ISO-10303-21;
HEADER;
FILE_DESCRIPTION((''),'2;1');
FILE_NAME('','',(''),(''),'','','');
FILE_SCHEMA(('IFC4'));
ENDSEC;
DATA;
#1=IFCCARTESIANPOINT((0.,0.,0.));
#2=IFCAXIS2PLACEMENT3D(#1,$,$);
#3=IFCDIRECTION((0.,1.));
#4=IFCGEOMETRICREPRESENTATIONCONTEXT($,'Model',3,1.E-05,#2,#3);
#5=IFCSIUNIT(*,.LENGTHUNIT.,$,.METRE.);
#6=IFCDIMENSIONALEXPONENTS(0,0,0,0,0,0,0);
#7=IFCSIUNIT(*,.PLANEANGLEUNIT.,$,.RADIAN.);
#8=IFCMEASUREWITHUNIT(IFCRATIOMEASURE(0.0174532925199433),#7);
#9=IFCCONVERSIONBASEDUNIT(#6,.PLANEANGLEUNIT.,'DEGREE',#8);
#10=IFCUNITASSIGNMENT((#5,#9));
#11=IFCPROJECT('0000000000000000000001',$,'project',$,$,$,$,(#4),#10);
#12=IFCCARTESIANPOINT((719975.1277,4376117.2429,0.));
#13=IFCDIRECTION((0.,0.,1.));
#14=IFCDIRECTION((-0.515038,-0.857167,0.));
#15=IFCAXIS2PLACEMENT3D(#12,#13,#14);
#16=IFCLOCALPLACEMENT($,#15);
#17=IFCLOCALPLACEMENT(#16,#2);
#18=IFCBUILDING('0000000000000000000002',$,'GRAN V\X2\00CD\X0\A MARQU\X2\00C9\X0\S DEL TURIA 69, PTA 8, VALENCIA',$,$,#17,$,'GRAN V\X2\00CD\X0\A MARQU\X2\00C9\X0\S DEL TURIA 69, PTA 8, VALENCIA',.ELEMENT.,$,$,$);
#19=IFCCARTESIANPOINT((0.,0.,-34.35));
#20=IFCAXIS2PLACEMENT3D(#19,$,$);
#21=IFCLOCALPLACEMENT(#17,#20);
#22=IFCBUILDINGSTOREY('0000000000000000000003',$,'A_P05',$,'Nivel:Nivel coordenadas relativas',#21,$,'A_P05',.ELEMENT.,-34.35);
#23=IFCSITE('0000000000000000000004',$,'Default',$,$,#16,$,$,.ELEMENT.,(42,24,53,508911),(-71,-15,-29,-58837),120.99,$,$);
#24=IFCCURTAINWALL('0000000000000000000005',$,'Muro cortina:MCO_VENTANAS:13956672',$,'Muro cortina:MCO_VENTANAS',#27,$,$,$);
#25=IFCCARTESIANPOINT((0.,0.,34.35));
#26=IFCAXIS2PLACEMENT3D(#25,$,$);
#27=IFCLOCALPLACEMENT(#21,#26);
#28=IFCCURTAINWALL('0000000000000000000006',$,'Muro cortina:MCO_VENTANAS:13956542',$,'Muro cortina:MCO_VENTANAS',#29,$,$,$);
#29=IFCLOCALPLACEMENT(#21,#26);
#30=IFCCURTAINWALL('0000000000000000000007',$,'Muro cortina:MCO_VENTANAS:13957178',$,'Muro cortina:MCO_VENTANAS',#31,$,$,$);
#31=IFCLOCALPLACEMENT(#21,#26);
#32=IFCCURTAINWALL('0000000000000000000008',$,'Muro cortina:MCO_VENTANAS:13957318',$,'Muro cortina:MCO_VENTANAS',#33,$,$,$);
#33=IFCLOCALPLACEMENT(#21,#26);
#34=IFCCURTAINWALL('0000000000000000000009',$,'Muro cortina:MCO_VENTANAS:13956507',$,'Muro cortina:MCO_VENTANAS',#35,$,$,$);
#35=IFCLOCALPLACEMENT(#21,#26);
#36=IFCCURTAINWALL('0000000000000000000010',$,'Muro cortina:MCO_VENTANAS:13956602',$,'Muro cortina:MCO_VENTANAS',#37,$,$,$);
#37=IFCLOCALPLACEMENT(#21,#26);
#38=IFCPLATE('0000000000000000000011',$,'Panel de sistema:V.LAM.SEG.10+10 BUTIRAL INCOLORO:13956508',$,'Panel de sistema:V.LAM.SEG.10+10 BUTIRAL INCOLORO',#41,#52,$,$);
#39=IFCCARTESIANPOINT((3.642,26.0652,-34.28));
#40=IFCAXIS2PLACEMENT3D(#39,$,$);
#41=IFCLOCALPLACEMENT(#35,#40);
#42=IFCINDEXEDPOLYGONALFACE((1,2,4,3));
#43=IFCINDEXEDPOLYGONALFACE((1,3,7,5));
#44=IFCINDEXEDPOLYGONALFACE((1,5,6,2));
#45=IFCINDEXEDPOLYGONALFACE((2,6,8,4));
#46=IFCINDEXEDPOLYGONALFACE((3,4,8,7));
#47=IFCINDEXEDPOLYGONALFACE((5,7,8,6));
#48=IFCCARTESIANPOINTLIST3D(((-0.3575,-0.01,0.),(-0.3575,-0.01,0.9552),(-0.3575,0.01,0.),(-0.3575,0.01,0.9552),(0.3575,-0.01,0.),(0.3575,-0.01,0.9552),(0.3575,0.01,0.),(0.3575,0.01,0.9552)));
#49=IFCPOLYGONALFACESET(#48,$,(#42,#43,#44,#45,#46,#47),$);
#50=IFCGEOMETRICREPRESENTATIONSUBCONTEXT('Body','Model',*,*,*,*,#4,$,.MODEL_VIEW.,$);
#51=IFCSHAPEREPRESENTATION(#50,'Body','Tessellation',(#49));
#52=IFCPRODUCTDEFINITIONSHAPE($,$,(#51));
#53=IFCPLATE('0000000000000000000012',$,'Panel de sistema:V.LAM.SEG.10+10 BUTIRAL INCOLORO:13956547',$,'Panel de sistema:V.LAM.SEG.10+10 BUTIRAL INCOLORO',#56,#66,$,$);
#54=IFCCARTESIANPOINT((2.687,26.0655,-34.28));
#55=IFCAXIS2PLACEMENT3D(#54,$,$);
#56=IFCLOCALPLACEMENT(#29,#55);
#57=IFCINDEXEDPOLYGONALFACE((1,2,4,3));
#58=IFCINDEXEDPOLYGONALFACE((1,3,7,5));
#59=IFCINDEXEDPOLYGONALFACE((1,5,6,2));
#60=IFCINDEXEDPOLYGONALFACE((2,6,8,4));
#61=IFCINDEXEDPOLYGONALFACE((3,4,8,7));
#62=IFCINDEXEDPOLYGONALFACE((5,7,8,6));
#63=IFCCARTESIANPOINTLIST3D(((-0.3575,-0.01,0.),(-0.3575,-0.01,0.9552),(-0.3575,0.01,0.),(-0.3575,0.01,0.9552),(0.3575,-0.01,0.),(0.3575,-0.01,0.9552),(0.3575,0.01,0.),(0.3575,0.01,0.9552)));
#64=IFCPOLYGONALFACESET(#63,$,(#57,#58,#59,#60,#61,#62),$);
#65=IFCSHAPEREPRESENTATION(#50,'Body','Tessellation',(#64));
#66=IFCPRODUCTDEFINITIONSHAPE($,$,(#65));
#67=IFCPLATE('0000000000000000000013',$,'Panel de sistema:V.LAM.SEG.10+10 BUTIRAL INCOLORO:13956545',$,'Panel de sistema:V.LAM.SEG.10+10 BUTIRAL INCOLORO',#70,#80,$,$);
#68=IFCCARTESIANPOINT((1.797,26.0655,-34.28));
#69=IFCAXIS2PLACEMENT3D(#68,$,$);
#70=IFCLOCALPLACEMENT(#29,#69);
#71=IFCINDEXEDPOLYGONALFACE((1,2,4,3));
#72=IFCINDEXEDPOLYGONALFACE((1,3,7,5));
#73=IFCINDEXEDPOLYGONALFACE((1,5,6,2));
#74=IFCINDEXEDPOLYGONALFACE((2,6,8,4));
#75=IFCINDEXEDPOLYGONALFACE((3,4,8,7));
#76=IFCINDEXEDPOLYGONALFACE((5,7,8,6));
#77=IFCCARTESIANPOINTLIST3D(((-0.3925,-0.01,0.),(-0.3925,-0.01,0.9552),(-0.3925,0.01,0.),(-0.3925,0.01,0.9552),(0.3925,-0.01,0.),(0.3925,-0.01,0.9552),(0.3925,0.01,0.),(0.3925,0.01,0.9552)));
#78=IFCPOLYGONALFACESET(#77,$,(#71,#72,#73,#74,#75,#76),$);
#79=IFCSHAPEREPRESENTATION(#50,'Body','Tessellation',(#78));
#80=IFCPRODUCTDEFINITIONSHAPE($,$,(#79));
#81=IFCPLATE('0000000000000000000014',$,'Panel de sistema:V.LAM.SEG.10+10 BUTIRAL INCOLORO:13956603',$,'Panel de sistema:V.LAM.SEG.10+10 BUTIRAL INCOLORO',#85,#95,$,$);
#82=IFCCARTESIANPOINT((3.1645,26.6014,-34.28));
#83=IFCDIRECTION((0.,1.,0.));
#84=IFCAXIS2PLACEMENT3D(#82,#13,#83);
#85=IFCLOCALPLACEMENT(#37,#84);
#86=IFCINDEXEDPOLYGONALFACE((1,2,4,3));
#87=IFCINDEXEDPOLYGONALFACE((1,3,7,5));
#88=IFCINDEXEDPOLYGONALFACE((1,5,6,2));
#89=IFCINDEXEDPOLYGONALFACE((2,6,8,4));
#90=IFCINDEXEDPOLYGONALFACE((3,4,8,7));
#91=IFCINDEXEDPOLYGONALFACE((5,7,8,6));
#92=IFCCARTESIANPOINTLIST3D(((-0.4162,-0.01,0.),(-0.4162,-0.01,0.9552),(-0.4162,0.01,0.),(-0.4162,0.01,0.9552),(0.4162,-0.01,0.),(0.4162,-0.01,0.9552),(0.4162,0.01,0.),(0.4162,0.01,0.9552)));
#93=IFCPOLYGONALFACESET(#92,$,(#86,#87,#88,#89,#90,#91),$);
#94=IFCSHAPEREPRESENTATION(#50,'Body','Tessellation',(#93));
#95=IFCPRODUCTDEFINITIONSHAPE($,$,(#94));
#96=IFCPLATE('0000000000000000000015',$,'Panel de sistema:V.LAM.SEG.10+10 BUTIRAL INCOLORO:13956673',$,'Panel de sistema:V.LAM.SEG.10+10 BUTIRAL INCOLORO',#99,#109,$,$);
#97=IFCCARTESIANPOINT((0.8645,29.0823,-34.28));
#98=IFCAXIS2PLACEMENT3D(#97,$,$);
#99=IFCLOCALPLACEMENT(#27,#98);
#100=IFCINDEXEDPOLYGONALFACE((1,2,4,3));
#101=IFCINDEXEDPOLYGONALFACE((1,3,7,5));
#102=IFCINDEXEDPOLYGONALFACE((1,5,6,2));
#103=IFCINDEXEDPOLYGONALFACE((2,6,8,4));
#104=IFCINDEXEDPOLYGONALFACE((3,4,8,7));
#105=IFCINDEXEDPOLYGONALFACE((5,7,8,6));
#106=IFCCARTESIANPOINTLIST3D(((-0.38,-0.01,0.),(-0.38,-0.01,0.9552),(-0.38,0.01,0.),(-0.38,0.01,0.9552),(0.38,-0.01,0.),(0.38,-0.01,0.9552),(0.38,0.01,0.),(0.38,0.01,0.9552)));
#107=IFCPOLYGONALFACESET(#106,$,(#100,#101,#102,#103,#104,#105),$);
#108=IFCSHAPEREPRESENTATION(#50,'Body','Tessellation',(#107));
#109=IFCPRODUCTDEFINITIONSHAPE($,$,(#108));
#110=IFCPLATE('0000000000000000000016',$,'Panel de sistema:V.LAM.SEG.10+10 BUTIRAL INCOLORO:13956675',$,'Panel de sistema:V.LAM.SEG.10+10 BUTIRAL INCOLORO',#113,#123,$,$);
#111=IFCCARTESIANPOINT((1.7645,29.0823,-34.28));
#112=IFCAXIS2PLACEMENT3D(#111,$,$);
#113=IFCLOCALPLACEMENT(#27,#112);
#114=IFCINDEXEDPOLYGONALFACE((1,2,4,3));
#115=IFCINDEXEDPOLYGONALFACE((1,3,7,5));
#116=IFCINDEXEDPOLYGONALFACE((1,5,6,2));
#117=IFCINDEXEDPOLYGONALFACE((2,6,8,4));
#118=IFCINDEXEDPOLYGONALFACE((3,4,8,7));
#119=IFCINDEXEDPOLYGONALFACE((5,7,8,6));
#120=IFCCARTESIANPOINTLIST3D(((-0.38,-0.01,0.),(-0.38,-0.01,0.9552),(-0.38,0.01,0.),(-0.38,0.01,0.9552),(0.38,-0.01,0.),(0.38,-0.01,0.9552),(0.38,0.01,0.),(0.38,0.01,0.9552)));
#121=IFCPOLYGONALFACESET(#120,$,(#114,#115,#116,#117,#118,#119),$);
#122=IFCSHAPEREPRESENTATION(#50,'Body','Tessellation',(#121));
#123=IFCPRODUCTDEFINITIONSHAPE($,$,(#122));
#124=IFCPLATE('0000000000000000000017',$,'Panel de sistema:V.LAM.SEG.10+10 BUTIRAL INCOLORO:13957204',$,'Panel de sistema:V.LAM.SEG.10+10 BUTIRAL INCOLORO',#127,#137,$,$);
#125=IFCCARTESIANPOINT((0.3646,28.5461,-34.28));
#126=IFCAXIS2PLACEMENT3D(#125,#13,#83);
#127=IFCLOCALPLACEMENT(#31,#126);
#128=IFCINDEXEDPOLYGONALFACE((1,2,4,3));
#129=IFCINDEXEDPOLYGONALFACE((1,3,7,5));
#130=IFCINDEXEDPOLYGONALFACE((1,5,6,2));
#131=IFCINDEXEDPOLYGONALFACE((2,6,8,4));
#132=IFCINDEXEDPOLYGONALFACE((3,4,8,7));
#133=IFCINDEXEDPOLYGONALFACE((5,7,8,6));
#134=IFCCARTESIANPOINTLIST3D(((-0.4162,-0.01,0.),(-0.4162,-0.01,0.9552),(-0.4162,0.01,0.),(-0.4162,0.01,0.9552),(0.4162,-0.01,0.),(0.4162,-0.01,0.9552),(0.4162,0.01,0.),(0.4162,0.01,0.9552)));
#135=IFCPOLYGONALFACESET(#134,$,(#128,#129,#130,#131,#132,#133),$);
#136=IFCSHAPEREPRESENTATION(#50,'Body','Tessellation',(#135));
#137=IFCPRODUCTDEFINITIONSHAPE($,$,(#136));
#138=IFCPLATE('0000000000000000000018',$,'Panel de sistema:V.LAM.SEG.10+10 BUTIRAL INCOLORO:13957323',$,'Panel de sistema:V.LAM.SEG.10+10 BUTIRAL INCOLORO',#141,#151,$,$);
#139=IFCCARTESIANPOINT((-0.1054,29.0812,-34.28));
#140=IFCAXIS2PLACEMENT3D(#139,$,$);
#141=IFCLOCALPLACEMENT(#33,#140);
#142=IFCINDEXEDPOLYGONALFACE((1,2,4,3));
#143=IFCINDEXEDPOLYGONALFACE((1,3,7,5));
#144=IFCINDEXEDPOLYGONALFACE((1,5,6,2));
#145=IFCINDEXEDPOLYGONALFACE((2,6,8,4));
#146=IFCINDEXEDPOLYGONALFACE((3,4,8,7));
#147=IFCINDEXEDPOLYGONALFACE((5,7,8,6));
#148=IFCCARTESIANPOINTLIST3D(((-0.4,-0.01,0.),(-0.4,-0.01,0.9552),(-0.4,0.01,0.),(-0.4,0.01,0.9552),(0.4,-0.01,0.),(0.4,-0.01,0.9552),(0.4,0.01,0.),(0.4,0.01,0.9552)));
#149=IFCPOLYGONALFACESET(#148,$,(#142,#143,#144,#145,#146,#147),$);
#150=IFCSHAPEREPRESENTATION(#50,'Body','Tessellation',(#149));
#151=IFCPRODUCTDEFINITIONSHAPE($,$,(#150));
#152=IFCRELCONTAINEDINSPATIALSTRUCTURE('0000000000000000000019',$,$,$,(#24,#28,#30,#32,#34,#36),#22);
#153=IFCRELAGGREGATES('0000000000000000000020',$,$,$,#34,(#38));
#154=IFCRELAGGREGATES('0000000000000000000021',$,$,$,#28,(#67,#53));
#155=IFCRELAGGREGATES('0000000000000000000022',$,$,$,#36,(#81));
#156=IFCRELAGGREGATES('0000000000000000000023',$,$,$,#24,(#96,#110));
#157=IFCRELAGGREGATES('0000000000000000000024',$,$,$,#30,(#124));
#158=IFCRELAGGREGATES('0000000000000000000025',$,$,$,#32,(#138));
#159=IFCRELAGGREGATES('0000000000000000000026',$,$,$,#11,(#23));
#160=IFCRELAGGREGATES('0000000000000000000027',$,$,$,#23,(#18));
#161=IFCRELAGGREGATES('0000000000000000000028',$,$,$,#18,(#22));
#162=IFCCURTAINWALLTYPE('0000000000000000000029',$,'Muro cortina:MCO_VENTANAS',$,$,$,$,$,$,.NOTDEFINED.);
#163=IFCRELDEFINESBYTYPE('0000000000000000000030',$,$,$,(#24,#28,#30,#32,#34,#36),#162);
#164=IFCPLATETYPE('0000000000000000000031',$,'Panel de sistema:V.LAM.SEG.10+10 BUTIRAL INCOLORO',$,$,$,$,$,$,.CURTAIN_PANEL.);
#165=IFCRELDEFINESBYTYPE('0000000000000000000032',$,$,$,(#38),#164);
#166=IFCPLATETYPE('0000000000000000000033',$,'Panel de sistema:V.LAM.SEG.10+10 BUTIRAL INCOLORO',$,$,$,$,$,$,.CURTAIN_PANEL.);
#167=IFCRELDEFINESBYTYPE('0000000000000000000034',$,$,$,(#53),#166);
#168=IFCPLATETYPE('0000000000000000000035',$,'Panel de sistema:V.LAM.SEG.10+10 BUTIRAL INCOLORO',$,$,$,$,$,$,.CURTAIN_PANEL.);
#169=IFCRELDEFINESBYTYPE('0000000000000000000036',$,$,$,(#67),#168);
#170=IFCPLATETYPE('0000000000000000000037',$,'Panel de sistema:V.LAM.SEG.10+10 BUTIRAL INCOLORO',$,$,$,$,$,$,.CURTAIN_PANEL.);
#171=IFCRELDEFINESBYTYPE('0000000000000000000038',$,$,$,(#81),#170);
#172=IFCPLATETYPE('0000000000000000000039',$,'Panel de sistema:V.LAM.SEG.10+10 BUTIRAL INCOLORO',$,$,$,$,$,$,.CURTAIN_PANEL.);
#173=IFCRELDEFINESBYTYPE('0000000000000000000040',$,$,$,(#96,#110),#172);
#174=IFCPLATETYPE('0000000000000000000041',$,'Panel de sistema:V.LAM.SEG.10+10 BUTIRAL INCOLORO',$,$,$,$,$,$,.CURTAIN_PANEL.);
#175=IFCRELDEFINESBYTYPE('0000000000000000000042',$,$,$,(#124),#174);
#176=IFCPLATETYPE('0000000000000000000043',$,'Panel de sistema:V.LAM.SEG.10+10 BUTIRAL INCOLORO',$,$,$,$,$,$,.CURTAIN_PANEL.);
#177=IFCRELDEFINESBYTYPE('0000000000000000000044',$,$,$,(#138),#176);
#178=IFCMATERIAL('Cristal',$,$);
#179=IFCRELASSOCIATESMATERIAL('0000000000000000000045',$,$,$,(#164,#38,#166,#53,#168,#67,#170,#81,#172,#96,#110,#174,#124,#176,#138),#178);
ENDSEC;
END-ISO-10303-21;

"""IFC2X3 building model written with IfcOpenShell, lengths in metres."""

from ifc_helpers import new_model, entity, si_unit, converted_unit, direction, frame, frame_2d, origin, origin_2d_with_axis, place, context, subcontext, project, spatial, rectangle, extrude, source, transform, mapped, material, type_object, type_shapes, element, aggregate, save


model = new_model("IFC2X3")

# Units and contexts
model_context = context("Model", 3, precision=1e-05, world=origin(), true_north=direction((0.0, 1.0)))
body_context = subcontext(model_context, "Body", "Model", "MODEL_VIEW")
ifc_project = project(units=[si_unit("LENGTHUNIT", "METRE"), converted_unit("PLANEANGLEUNIT", "DEGREE", entity("IfcRatioMeasure", 0.0174532925199433), si_unit("PLANEANGLEUNIT", "RADIAN"), dimensions=[0, 0, 0, 0, 0, 0, 0])], contexts=[model_context])

# Site, building, storey
site_placement = place(None, frame((719975.1277, 4376117.2429, 0.0), z_axis=(0.0, 0.0, 1.0), x_axis=(-0.515038, -0.857167, 0.0)))
site = spatial("IfcSite", under=ifc_project, at=site_placement, Name="Default", CompositionType="ELEMENT", RefLatitude=(42, 24, 53, 508911), RefLongitude=(-71, -15, -29, -58837), RefElevation=120.99)
building_placement = place(site_placement, origin())
building = spatial("IfcBuilding", under=site, at=building_placement, Name="GRAN VÍA MARQUÉS DEL TURIA 69, PTA 8, VALENCIA", LongName="GRAN VÍA MARQUÉS DEL TURIA 69, PTA 8, VALENCIA", CompositionType="ELEMENT")
storey_placement = place(building_placement, frame((0.0, 0.0, -34.35)))
storey = spatial("IfcBuildingStorey", under=building, at=storey_placement, Name="A_P05", ObjectType="Nivel:Nivel coordenadas relativas", LongName="A_P05", CompositionType="ELEMENT", Elevation=-34.35)

# Curtain wall
curtain_wall_type = type_object("IfcCurtainWallType", Name="Muro cortina:MCO_VENTANAS", PredefinedType="NOTDEFINED")
curtain_wall_1_placement = place(storey_placement, frame((0.0, 0.0, 34.35)))
curtain_wall_1 = element("IfcCurtainWall", 1, at=curtain_wall_1_placement, inside=storey, type_object=curtain_wall_type, Name="Muro cortina:MCO_VENTANAS:13956672", ObjectType="Muro cortina:MCO_VENTANAS")

# Curtain walls
curtain_wall_2_placement = place(storey_placement, frame((0.0, 0.0, 34.35)))
curtain_wall_2 = element("IfcCurtainWall", 2, at=curtain_wall_2_placement, inside=storey, type_object=curtain_wall_type, Name="Muro cortina:MCO_VENTANAS:13956542", ObjectType="Muro cortina:MCO_VENTANAS")
curtain_wall_3_placement = place(storey_placement, frame((0.0, 0.0, 34.35)))
curtain_wall_3 = element("IfcCurtainWall", 3, at=curtain_wall_3_placement, inside=storey, type_object=curtain_wall_type, Name="Muro cortina:MCO_VENTANAS:13957178", ObjectType="Muro cortina:MCO_VENTANAS")
curtain_wall_4_placement = place(storey_placement, frame((0.0, 0.0, 34.35)))
curtain_wall_4 = element("IfcCurtainWall", 4, at=curtain_wall_4_placement, inside=storey, type_object=curtain_wall_type, Name="Muro cortina:MCO_VENTANAS:13957318", ObjectType="Muro cortina:MCO_VENTANAS")
curtain_wall_5_placement = place(storey_placement, frame((0.0, 0.0, 34.35)))
curtain_wall_5 = element("IfcCurtainWall", 5, at=curtain_wall_5_placement, inside=storey, type_object=curtain_wall_type, Name="Muro cortina:MCO_VENTANAS:13956507", ObjectType="Muro cortina:MCO_VENTANAS")
curtain_wall_6_placement = place(storey_placement, frame((0.0, 0.0, 34.35)))
curtain_wall_6 = element("IfcCurtainWall", 6, at=curtain_wall_6_placement, inside=storey, type_object=curtain_wall_type, Name="Muro cortina:MCO_VENTANAS:13956602", ObjectType="Muro cortina:MCO_VENTANAS")

# Plates
ifc_material_1 = material(Name="Cristal")
plate_type_1 = type_object("IfcPlateType", Name="Panel de sistema:V.LAM.SEG.10+10 BUTIRAL INCOLORO", PredefinedType="CURTAIN_PANEL", material=ifc_material_1)
shared_shape_1 = source(origin(), body_context, "Body", "SweptSolid", [
    extrude(rectangle(XDim=0.02, YDim=0.715, at=origin_2d_with_axis()), frame((0.0, 0.0, 0.0), z_axis=(0.0, 0.0, 1.0), x_axis=(0.0, 1.0, 0.0)), (0.0, 0.0, 1.0), 0.9552),
])
type_shapes(plate_type_1, [shared_shape_1])
plate_1_placement = place(curtain_wall_5_placement, frame((3.642, 26.0652, -34.28)))
plate_1 = element("IfcPlate", 7, at=plate_1_placement, type_object=plate_type_1, material=ifc_material_1, Name="Panel de sistema:V.LAM.SEG.10+10 BUTIRAL INCOLORO:13956508", ObjectType="Panel de sistema:V.LAM.SEG.10+10 BUTIRAL INCOLORO", context=body_context, shape_type="MappedRepresentation", body=[
    mapped(shared_shape_1, transform((0.0, 0.0, 0.0), scale=1.0)),
])
aggregate(curtain_wall_5, [plate_1])
plate_type_2 = type_object("IfcPlateType", Name="Panel de sistema:V.LAM.SEG.10+10 BUTIRAL INCOLORO", PredefinedType="CURTAIN_PANEL", material=ifc_material_1)
shared_shape_2 = source(origin(), body_context, "Body", "SweptSolid", [
    extrude(rectangle(XDim=0.02, YDim=0.715, at=origin_2d_with_axis()), frame((0.0, 0.0, 0.0), z_axis=(0.0, 0.0, 1.0), x_axis=(0.0, 1.0, 0.0)), (0.0, 0.0, 1.0), 0.9552),
])
type_shapes(plate_type_2, [shared_shape_2])
plate_2_placement = place(curtain_wall_2_placement, frame((2.687, 26.0655, -34.28)))
plate_2 = element("IfcPlate", 8, at=plate_2_placement, type_object=plate_type_2, material=ifc_material_1, Name="Panel de sistema:V.LAM.SEG.10+10 BUTIRAL INCOLORO:13956547", ObjectType="Panel de sistema:V.LAM.SEG.10+10 BUTIRAL INCOLORO", context=body_context, shape_type="MappedRepresentation", body=[
    mapped(shared_shape_2, transform((0.0, 0.0, 0.0), scale=1.0)),
])
plate_type_3 = type_object("IfcPlateType", Name="Panel de sistema:V.LAM.SEG.10+10 BUTIRAL INCOLORO", PredefinedType="CURTAIN_PANEL", material=ifc_material_1)
shared_shape_3 = source(origin(), body_context, "Body", "SweptSolid", [
    extrude(rectangle(XDim=0.02, YDim=0.785, at=origin_2d_with_axis()), frame((0.0, 0.0, 0.0), z_axis=(0.0, 0.0, 1.0), x_axis=(0.0, 1.0, 0.0)), (0.0, 0.0, 1.0), 0.9552),
])
type_shapes(plate_type_3, [shared_shape_3])
plate_3_placement = place(curtain_wall_2_placement, frame((1.797, 26.0655, -34.28)))
plate_3 = element("IfcPlate", 9, at=plate_3_placement, type_object=plate_type_3, material=ifc_material_1, Name="Panel de sistema:V.LAM.SEG.10+10 BUTIRAL INCOLORO:13956545", ObjectType="Panel de sistema:V.LAM.SEG.10+10 BUTIRAL INCOLORO", context=body_context, shape_type="MappedRepresentation", body=[
    mapped(shared_shape_3, transform((0.0, 0.0, 0.0), scale=1.0)),
])
aggregate(curtain_wall_2, [plate_3, plate_2])
plate_type_4 = type_object("IfcPlateType", Name="Panel de sistema:V.LAM.SEG.10+10 BUTIRAL INCOLORO", PredefinedType="CURTAIN_PANEL", material=ifc_material_1)
shared_shape_4 = source(origin(), body_context, "Body", "SweptSolid", [
    extrude(rectangle(XDim=0.02, YDim=0.8324, at=frame_2d((0.0, 0.0), x_axis=(1.0, 0.0))), frame((0.0, 0.0, 0.0), z_axis=(0.0, 0.0, 1.0), x_axis=(0.0, 1.0, 0.0)), (0.0, 0.0, 1.0), 0.9552),
])
type_shapes(plate_type_4, [shared_shape_4])
plate_4_placement = place(curtain_wall_6_placement, frame((3.1645, 26.6014, -34.28), z_axis=(0.0, 0.0, 1.0), x_axis=(0.0, 1.0, 0.0)))
plate_4 = element("IfcPlate", 10, at=plate_4_placement, type_object=plate_type_4, material=ifc_material_1, Name="Panel de sistema:V.LAM.SEG.10+10 BUTIRAL INCOLORO:13956603", ObjectType="Panel de sistema:V.LAM.SEG.10+10 BUTIRAL INCOLORO", context=body_context, shape_type="MappedRepresentation", body=[
    mapped(shared_shape_4, transform((0.0, 0.0, 0.0), scale=1.0)),
])
aggregate(curtain_wall_6, [plate_4])
plate_type_5 = type_object("IfcPlateType", Name="Panel de sistema:V.LAM.SEG.10+10 BUTIRAL INCOLORO", PredefinedType="CURTAIN_PANEL", material=ifc_material_1)
shared_shape_5 = source(origin(), body_context, "Body", "SweptSolid", [
    extrude(rectangle(XDim=0.02, YDim=0.76, at=origin_2d_with_axis()), frame((0.0, 0.0, 0.0), z_axis=(0.0, 0.0, 1.0), x_axis=(0.0, 1.0, 0.0)), (0.0, 0.0, 1.0), 0.9552),
])
type_shapes(plate_type_5, [shared_shape_5])
plate_5_placement = place(curtain_wall_1_placement, frame((0.8645, 29.0823, -34.28)))
plate_5 = element("IfcPlate", 11, at=plate_5_placement, type_object=plate_type_5, material=ifc_material_1, Name="Panel de sistema:V.LAM.SEG.10+10 BUTIRAL INCOLORO:13956673", ObjectType="Panel de sistema:V.LAM.SEG.10+10 BUTIRAL INCOLORO", context=body_context, shape_type="MappedRepresentation", body=[
    mapped(shared_shape_5, transform((0.0, 0.0, 0.0), scale=1.0)),
])
plate_6_placement = place(curtain_wall_1_placement, frame((1.7645, 29.0823, -34.28)))
plate_6 = element("IfcPlate", 12, at=plate_6_placement, type_object=plate_type_5, material=ifc_material_1, Name="Panel de sistema:V.LAM.SEG.10+10 BUTIRAL INCOLORO:13956675", ObjectType="Panel de sistema:V.LAM.SEG.10+10 BUTIRAL INCOLORO", context=body_context, shape_type="MappedRepresentation", body=[
    mapped(shared_shape_5, transform((0.0, 0.0, 0.0), scale=1.0)),
])
aggregate(curtain_wall_1, [plate_5, plate_6])
plate_type_6 = type_object("IfcPlateType", Name="Panel de sistema:V.LAM.SEG.10+10 BUTIRAL INCOLORO", PredefinedType="CURTAIN_PANEL", material=ifc_material_1)
shared_shape_6 = source(origin(), body_context, "Body", "SweptSolid", [
    extrude(rectangle(XDim=0.02, YDim=0.8323, at=origin_2d_with_axis()), frame((0.0, 0.0, 0.0), z_axis=(0.0, 0.0, 1.0), x_axis=(0.0, 1.0, 0.0)), (0.0, 0.0, 1.0), 0.9552),
])
type_shapes(plate_type_6, [shared_shape_6])
plate_7_placement = place(curtain_wall_3_placement, frame((0.3646, 28.5461, -34.28), z_axis=(0.0, 0.0, 1.0), x_axis=(0.0, 1.0, 0.0)))
plate_7 = element("IfcPlate", 13, at=plate_7_placement, type_object=plate_type_6, material=ifc_material_1, Name="Panel de sistema:V.LAM.SEG.10+10 BUTIRAL INCOLORO:13957204", ObjectType="Panel de sistema:V.LAM.SEG.10+10 BUTIRAL INCOLORO", context=body_context, shape_type="MappedRepresentation", body=[
    mapped(shared_shape_6, transform((0.0, 0.0, 0.0), scale=1.0)),
])
aggregate(curtain_wall_3, [plate_7])
plate_type_7 = type_object("IfcPlateType", Name="Panel de sistema:V.LAM.SEG.10+10 BUTIRAL INCOLORO", PredefinedType="CURTAIN_PANEL", material=ifc_material_1)
shared_shape_7 = source(origin(), body_context, "Body", "SweptSolid", [
    extrude(rectangle(XDim=0.02, YDim=0.8, at=origin_2d_with_axis()), frame((0.0, 0.0, 0.0), z_axis=(0.0, 0.0, 1.0), x_axis=(0.0, 1.0, 0.0)), (0.0, 0.0, 1.0), 0.9552),
])
type_shapes(plate_type_7, [shared_shape_7])
plate_8_placement = place(curtain_wall_4_placement, frame((-0.1054, 29.0812, -34.28)))
plate_8 = element("IfcPlate", 14, at=plate_8_placement, type_object=plate_type_7, material=ifc_material_1, Name="Panel de sistema:V.LAM.SEG.10+10 BUTIRAL INCOLORO:13957323", ObjectType="Panel de sistema:V.LAM.SEG.10+10 BUTIRAL INCOLORO", context=body_context, shape_type="MappedRepresentation", body=[
    mapped(shared_shape_7, transform((0.0, 0.0, 0.0), scale=1.0)),
])
aggregate(curtain_wall_4, [plate_8])

save(model, "model.ifc")
